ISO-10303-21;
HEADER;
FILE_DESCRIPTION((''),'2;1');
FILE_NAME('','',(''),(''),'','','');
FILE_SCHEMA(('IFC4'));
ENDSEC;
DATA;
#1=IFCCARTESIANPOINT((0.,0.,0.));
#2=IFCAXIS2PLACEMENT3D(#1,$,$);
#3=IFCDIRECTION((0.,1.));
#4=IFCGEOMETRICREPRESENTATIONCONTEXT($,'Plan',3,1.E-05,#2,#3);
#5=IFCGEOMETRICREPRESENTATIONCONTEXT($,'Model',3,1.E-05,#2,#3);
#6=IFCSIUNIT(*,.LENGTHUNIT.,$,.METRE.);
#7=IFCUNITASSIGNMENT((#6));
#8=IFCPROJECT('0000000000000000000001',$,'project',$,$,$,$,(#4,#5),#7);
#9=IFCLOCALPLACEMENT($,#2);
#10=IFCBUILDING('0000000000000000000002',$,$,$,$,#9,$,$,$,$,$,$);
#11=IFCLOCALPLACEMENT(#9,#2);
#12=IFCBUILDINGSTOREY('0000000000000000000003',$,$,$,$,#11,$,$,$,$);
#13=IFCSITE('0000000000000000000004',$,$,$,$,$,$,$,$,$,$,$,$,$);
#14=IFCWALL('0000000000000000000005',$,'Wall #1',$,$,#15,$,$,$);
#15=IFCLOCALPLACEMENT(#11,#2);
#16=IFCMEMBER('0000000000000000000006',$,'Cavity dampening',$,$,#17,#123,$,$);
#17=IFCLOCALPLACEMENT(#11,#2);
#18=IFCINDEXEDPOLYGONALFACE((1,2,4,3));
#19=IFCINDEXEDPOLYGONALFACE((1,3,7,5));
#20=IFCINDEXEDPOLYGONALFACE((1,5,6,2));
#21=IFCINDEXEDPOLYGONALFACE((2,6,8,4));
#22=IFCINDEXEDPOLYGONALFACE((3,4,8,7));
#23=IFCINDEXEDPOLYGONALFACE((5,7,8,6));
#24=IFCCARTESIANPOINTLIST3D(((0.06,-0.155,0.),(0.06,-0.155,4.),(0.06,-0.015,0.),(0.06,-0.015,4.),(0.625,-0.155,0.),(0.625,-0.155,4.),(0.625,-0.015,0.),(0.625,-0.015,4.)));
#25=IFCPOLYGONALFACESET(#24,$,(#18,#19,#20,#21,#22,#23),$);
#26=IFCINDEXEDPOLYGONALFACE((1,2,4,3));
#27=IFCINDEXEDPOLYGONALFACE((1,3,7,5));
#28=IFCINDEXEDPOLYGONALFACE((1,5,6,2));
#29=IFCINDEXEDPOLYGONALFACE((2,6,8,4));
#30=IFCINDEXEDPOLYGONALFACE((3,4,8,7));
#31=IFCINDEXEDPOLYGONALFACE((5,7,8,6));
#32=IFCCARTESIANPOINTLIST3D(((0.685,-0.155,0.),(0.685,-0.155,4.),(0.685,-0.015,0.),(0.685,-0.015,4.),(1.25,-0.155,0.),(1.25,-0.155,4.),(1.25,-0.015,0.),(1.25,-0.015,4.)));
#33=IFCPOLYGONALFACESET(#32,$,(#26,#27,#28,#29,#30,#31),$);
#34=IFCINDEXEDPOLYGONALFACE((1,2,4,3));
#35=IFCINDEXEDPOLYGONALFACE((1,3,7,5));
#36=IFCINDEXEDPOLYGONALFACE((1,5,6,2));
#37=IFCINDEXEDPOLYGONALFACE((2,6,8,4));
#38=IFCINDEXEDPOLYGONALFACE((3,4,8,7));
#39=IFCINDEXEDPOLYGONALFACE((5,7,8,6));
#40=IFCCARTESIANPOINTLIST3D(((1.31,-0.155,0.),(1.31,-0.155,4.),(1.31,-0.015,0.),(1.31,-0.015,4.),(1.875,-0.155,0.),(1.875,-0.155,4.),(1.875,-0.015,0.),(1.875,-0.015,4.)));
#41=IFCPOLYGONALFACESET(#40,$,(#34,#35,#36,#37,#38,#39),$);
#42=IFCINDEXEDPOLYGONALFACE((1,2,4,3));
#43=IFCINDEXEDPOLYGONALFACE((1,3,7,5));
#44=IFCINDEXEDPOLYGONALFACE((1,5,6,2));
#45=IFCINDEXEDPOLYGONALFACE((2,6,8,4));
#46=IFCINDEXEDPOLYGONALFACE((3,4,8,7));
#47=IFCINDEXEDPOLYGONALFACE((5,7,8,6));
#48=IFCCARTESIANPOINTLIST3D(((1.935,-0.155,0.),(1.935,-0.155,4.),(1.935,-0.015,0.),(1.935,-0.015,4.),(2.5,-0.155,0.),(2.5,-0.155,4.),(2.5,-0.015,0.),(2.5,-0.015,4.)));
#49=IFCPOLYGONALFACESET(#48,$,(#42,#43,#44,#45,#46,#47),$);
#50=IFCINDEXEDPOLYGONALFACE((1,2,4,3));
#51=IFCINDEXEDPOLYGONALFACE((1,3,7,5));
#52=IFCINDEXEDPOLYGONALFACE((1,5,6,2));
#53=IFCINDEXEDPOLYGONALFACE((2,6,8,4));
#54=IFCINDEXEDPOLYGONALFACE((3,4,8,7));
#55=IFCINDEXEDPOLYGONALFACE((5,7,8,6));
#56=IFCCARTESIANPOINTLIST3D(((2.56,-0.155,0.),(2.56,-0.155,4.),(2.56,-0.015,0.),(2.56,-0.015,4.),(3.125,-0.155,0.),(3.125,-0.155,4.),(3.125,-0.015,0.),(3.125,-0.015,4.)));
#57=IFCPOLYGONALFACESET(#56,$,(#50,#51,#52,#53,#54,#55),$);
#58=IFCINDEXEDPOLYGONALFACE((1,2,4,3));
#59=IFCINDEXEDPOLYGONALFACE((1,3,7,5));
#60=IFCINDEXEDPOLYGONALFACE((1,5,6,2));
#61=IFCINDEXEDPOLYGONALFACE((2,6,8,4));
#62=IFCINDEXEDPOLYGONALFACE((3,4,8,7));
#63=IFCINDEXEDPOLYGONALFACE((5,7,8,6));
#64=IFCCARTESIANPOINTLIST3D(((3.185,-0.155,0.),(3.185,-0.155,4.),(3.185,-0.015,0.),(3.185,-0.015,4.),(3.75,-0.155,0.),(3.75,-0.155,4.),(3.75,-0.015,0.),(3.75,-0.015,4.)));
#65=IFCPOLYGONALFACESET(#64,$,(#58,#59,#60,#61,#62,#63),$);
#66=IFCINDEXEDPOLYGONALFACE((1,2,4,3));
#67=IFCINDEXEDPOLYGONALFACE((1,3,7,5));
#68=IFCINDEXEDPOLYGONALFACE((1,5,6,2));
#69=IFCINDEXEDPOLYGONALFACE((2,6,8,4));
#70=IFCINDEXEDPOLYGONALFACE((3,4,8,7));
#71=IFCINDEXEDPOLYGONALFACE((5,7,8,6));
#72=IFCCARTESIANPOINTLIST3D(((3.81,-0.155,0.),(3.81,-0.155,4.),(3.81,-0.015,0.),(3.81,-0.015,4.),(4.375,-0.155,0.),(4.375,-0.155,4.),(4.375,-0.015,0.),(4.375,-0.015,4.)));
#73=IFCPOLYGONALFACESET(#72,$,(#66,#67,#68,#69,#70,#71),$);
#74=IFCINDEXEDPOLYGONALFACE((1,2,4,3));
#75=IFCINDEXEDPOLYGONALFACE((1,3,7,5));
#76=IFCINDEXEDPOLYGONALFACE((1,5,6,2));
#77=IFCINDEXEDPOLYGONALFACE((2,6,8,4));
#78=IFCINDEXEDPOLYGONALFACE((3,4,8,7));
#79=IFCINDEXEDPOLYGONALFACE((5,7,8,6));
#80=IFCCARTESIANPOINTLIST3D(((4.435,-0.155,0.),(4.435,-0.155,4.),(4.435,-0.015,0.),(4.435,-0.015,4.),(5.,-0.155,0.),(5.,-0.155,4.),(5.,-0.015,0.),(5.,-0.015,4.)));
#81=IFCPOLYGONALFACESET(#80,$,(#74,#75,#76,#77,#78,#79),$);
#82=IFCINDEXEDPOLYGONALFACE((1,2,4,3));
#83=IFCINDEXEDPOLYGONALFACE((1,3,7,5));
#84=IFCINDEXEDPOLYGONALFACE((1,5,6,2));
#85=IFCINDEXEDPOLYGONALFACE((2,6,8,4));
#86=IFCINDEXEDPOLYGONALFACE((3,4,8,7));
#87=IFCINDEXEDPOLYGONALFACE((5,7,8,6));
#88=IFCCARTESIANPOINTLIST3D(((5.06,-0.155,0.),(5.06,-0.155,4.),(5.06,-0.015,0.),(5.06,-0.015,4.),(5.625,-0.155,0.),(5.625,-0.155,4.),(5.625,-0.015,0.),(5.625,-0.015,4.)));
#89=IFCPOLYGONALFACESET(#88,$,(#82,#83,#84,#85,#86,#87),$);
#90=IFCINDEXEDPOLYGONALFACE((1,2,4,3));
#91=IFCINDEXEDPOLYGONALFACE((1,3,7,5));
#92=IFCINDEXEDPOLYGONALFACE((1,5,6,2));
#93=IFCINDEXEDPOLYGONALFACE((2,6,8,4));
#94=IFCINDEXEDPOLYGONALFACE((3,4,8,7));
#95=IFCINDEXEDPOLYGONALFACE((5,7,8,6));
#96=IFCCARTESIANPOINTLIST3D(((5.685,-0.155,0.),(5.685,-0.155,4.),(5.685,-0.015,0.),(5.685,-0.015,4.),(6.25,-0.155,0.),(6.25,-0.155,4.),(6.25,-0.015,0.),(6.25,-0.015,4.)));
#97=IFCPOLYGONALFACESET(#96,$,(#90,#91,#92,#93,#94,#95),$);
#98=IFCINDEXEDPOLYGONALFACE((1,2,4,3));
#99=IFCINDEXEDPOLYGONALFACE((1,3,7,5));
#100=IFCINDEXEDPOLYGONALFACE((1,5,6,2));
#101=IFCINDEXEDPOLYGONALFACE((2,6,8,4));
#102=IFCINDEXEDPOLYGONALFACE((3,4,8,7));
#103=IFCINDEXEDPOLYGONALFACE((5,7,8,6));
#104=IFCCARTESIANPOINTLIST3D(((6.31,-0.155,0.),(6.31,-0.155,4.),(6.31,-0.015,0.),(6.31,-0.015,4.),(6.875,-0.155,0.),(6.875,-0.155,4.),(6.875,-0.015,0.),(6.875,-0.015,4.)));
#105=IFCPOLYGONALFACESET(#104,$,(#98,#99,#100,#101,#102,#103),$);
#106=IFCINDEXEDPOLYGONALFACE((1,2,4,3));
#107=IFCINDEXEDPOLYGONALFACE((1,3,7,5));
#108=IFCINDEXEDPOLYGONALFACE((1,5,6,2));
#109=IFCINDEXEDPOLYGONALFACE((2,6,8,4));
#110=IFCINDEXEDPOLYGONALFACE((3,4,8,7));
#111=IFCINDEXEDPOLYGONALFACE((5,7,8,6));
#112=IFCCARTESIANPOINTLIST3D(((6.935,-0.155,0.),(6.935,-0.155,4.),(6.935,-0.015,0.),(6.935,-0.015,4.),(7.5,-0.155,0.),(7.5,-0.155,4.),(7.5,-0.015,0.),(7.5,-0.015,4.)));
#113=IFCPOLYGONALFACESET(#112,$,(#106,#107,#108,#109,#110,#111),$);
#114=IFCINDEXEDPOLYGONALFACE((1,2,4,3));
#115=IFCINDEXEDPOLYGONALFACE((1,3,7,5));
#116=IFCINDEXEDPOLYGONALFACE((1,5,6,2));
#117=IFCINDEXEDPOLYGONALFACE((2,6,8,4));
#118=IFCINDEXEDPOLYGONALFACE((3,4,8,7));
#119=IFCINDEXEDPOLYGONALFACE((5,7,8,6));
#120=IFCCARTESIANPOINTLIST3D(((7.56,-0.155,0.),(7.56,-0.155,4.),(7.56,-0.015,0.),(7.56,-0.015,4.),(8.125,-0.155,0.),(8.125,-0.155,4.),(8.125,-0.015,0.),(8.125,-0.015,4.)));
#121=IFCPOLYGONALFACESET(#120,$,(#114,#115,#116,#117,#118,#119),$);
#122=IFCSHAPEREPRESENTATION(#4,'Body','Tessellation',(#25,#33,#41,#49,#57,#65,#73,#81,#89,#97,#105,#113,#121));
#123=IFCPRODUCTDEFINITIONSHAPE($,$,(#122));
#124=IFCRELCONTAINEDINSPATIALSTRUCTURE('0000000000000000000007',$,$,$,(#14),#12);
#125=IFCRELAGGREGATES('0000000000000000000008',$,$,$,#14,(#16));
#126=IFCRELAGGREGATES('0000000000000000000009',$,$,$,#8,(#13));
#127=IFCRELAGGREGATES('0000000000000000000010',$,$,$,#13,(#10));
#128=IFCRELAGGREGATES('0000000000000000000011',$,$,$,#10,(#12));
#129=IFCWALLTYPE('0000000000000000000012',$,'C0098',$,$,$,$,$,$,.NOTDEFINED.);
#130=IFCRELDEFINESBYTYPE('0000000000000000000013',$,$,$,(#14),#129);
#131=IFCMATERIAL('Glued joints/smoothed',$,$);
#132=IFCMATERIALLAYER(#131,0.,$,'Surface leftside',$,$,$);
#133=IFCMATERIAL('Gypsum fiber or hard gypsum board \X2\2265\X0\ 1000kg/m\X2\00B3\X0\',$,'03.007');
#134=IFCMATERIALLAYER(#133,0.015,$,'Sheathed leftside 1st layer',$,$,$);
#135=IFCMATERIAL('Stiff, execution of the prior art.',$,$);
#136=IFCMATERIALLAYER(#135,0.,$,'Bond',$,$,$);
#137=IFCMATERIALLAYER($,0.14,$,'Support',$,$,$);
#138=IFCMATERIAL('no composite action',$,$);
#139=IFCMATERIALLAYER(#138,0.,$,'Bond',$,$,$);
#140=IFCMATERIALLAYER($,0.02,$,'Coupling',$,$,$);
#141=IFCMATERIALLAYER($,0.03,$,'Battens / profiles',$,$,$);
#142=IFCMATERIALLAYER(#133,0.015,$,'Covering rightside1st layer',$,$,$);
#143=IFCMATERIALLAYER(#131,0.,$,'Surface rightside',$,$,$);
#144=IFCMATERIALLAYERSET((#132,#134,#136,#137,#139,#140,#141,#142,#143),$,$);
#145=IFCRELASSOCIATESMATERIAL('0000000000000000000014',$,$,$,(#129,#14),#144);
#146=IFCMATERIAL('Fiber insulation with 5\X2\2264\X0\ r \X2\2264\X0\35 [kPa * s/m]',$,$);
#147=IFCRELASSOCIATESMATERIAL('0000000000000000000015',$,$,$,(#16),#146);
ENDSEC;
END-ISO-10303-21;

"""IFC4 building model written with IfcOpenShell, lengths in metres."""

from ifc_helpers import new_model, si_unit, direction, frame, frame_2d, origin, place, context, project, spatial, rectangle, extrude, material, layer, layer_set, type_object, element, aggregate, save


model = new_model("IFC4")

# Units and contexts
plan_context = context("Plan", 3, precision=1e-05, world=origin(), true_north=direction((0.0, 1.0)))
model_context = context("Model", 3, precision=1e-05, world=origin(), true_north=direction((0.0, 1.0)))
ifc_project = project(units=[si_unit("LENGTHUNIT", "METRE")], contexts=[plan_context, model_context])

# Site, building, storey
site = spatial("IfcSite", under=ifc_project)
building_placement = place(None, origin())
building = spatial("IfcBuilding", under=site, at=building_placement)
storey_placement = place(building_placement, origin())
storey = spatial("IfcBuildingStorey", under=building, at=storey_placement)

# Wall, member
ifc_material_1 = material(Name="Glued joints/smoothed")
ifc_layer_1 = layer(ifc_material_1, 0.0, Name="Surface leftside")
ifc_material_2 = material(Name="Gypsum fiber or hard gypsum board ≥ 1000kg/m³", Category="03.007")
ifc_layer_2 = layer(ifc_material_2, 0.015, Name="Sheathed leftside 1st layer")
ifc_material_3 = material(Name="Stiff, execution of the prior art.")
ifc_layer_3 = layer(ifc_material_3, 0.0, Name="Bond")
ifc_layer_4 = layer(None, 0.14, Name="Support")
ifc_material_4 = material(Name="no composite action")
ifc_layer_5 = layer(ifc_material_4, 0.0, Name="Bond")
ifc_layer_6 = layer(None, 0.02, Name="Coupling")
ifc_layer_7 = layer(None, 0.03, Name="Battens / profiles")
ifc_layer_8 = layer(ifc_material_2, 0.015, Name="Covering rightside1st layer")
ifc_layer_9 = layer(ifc_material_1, 0.0, Name="Surface rightside")
ifc_layer_set = layer_set([ifc_layer_1, ifc_layer_2, ifc_layer_3, ifc_layer_4, ifc_layer_5, ifc_layer_6, ifc_layer_7, ifc_layer_8, ifc_layer_9])
wall_type = type_object("IfcWallType", Name="C0098", PredefinedType="NOTDEFINED", material=ifc_layer_set)
wall_placement = place(None, frame((0.0, 0.0, 0.0), z_axis=(0.0, -1.0, 0.0), x_axis=(1.0, 0.0, 0.0)))
wall = element("IfcWall", 1, at=wall_placement, inside=storey, type_object=wall_type, material=ifc_layer_set, Name="Wall #1")
ifc_material_5 = material(Name="Fiber insulation with 5≤ r ≤35 [kPa * s/m]")
member_1_placement = place(wall_placement, origin())
member_1 = element("IfcMember", 2, at=member_1_placement, material=ifc_material_5, Name="Cavity dampening", context=plan_context, shape_type="SweptSolid", body=[
    extrude(rectangle(XDim=0.565, YDim=0.14, at=frame_2d((0.2825, 0.07), x_axis=(1.0, 0.0))), frame((0.06, 4.0, 0.015), z_axis=(0.0, -1.0, 0.0), x_axis=(1.0, 0.0, 0.0)), (0.0, 0.0, 1.0), 4.0),
    extrude(rectangle(XDim=0.565, YDim=0.14, at=frame_2d((0.2825, 0.07), x_axis=(1.0, 0.0))), frame((0.685, 4.0, 0.015), z_axis=(0.0, -1.0, 0.0), x_axis=(1.0, 0.0, 0.0)), (0.0, 0.0, 1.0), 4.0),
    extrude(rectangle(XDim=0.565, YDim=0.14, at=frame_2d((0.2825, 0.07), x_axis=(1.0, 0.0))), frame((1.31, 4.0, 0.015), z_axis=(0.0, -1.0, 0.0), x_axis=(1.0, 0.0, 0.0)), (0.0, 0.0, 1.0), 4.0),
    extrude(rectangle(XDim=0.565, YDim=0.14, at=frame_2d((0.2825, 0.07), x_axis=(1.0, 0.0))), frame((1.935, 4.0, 0.015), z_axis=(0.0, -1.0, 0.0), x_axis=(1.0, 0.0, 0.0)), (0.0, 0.0, 1.0), 4.0),
    extrude(rectangle(XDim=0.565, YDim=0.14, at=frame_2d((0.2825, 0.07), x_axis=(1.0, 0.0))), frame((2.56, 4.0, 0.015), z_axis=(0.0, -1.0, 0.0), x_axis=(1.0, 0.0, 0.0)), (0.0, 0.0, 1.0), 4.0),
    extrude(rectangle(XDim=0.565, YDim=0.14, at=frame_2d((0.2825, 0.07), x_axis=(1.0, 0.0))), frame((3.185, 4.0, 0.015), z_axis=(0.0, -1.0, 0.0), x_axis=(1.0, 0.0, 0.0)), (0.0, 0.0, 1.0), 4.0),
    extrude(rectangle(XDim=0.565, YDim=0.14, at=frame_2d((0.2825, 0.07), x_axis=(1.0, 0.0))), frame((3.81, 4.0, 0.015), z_axis=(0.0, -1.0, 0.0), x_axis=(1.0, 0.0, 0.0)), (0.0, 0.0, 1.0), 4.0),
    extrude(rectangle(XDim=0.565, YDim=0.14, at=frame_2d((0.2825, 0.07), x_axis=(1.0, 0.0))), frame((4.435, 4.0, 0.015), z_axis=(0.0, -1.0, 0.0), x_axis=(1.0, 0.0, 0.0)), (0.0, 0.0, 1.0), 4.0),
    extrude(rectangle(XDim=0.565, YDim=0.14, at=frame_2d((0.2825, 0.07), x_axis=(1.0, 0.0))), frame((5.06, 4.0, 0.015), z_axis=(0.0, -1.0, 0.0), x_axis=(1.0, 0.0, 0.0)), (0.0, 0.0, 1.0), 4.0),
    extrude(rectangle(XDim=0.565, YDim=0.14, at=frame_2d((0.2825, 0.07), x_axis=(1.0, 0.0))), frame((5.685, 4.0, 0.015), z_axis=(0.0, -1.0, 0.0), x_axis=(1.0, 0.0, 0.0)), (0.0, 0.0, 1.0), 4.0),
    extrude(rectangle(XDim=0.565, YDim=0.14, at=frame_2d((0.2825, 0.07), x_axis=(1.0, 0.0))), frame((6.31, 4.0, 0.015), z_axis=(0.0, -1.0, 0.0), x_axis=(1.0, 0.0, 0.0)), (0.0, 0.0, 1.0), 4.0),
    extrude(rectangle(XDim=0.565, YDim=0.14, at=frame_2d((0.2825, 0.07), x_axis=(1.0, 0.0))), frame((6.935, 4.0, 0.015), z_axis=(0.0, -1.0, 0.0), x_axis=(1.0, 0.0, 0.0)), (0.0, 0.0, 1.0), 4.0),
    extrude(rectangle(XDim=0.565, YDim=0.14, at=frame_2d((0.2825, 0.07), x_axis=(1.0, 0.0))), frame((7.56, 4.0, 0.015), z_axis=(0.0, -1.0, 0.0), x_axis=(1.0, 0.0, 0.0)), (0.0, 0.0, 1.0), 4.0),
])
aggregate(wall, [member_1])

save(model, "model.ifc")
